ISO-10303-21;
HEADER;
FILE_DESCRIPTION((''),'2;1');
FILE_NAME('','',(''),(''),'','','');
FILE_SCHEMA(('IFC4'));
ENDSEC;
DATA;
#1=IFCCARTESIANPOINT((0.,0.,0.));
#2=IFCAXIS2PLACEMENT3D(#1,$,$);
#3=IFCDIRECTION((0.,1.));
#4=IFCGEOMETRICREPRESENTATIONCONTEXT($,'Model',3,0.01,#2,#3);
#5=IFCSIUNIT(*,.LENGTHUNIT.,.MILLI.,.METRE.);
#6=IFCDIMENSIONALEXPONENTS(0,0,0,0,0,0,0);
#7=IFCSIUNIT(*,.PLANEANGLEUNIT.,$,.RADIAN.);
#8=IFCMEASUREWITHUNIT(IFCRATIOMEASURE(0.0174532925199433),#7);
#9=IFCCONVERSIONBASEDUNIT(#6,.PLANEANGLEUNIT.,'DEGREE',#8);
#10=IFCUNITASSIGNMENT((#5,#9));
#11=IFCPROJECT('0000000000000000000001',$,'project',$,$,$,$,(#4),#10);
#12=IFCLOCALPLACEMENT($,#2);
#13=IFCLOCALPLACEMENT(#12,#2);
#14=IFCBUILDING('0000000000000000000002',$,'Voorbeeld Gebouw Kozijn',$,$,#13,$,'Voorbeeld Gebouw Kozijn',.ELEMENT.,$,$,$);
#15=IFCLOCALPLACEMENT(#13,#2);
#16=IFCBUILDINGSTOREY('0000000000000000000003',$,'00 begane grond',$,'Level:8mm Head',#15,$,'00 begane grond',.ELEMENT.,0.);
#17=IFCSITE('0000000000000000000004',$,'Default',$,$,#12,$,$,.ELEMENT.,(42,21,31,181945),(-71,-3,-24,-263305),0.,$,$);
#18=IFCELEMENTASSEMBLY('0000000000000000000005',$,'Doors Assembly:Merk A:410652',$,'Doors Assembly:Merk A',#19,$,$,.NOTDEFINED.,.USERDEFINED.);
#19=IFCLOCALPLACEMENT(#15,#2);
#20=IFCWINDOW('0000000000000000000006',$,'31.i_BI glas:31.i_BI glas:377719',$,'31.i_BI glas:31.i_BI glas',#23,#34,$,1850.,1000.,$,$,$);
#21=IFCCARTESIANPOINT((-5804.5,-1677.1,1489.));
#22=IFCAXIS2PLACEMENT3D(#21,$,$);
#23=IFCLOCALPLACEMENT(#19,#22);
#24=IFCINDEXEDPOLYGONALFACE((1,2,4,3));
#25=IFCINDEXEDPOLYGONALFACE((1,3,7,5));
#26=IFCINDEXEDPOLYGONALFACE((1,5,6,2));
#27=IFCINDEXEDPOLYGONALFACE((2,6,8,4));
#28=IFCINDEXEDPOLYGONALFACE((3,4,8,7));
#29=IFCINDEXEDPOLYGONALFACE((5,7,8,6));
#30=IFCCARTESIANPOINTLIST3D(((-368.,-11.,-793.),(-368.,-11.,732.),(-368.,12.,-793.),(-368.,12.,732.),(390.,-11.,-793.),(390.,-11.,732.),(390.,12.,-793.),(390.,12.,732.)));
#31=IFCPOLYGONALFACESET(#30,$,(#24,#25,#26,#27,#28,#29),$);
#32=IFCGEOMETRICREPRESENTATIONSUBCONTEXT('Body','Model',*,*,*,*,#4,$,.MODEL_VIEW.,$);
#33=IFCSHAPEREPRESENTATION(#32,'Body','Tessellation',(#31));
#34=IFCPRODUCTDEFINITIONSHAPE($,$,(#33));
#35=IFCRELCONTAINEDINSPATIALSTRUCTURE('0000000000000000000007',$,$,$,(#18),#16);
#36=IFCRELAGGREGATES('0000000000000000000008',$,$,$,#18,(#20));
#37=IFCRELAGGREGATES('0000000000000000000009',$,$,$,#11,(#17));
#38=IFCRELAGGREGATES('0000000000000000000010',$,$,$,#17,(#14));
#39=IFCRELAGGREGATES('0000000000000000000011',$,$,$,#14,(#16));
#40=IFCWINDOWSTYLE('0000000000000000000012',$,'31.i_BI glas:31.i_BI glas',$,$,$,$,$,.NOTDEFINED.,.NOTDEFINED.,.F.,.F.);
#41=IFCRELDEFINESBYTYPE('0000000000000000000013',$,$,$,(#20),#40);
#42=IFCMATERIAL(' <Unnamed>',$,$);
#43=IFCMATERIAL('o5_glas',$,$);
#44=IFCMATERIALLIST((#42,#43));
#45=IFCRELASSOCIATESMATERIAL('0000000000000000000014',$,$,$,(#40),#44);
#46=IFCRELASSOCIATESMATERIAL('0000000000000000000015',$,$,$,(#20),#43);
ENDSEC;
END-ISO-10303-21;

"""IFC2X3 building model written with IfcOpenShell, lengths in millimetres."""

from ifc_helpers import new_model, entity, si_unit, converted_unit, direction, frame, frame_2d, origin, place, context, subcontext, project, spatial, rectangle, extrude, source, transform, mapped, material, material_list, type_object, type_shapes, element, aggregate, save


model = new_model("IFC2X3")

# Units and contexts
model_context = context("Model", 3, precision=0.01, world=origin(), true_north=direction((0.0, 1.0)))
body_context = subcontext(model_context, "Body", "Model", "MODEL_VIEW")
ifc_project = project(units=[si_unit("LENGTHUNIT", "METRE", prefix="MILLI"), converted_unit("PLANEANGLEUNIT", "DEGREE", entity("IfcRatioMeasure", 0.0174532925199433), si_unit("PLANEANGLEUNIT", "RADIAN"), dimensions=[0, 0, 0, 0, 0, 0, 0])], contexts=[model_context])

# Site, building, storey
site_placement = place(None, origin())
site = spatial("IfcSite", under=ifc_project, at=site_placement, Name="Default", CompositionType="ELEMENT", RefLatitude=(42, 21, 31, 181945), RefLongitude=(-71, -3, -24, -263305), RefElevation=0.0)
building_placement = place(site_placement, origin())
building = spatial("IfcBuilding", under=site, at=building_placement, Name="Voorbeeld Gebouw Kozijn", LongName="Voorbeeld Gebouw Kozijn", CompositionType="ELEMENT")
storey_placement = place(building_placement, origin())
storey = spatial("IfcBuildingStorey", under=building, at=storey_placement, Name="00 begane grond", ObjectType="Level:8mm Head", LongName="00 begane grond", CompositionType="ELEMENT", Elevation=0.0)

# Element assembly, window
assembly_placement = place(storey_placement, origin())
assembly = element("IfcElementAssembly", 1, at=assembly_placement, inside=storey, Name="Doors Assembly:Merk A:410652", ObjectType="Doors Assembly:Merk A", AssemblyPlace="NOTDEFINED", PredefinedType="USERDEFINED")
ifc_material_1 = material(Name="o5_glas")
ifc_material_2 = material(Name=" <Unnamed>")
ifc_material_list = material_list([ifc_material_2, ifc_material_1])
window_style = type_object("IfcWindowStyle", Name="31.i_BI glas:31.i_BI glas", ConstructionType="NOTDEFINED", OperationType="NOTDEFINED", ParameterTakesPrecedence=False, Sizeable=False, material=ifc_material_list)
shared_shape = source(origin(), body_context, "Body", "SweptSolid", [
    extrude(rectangle(XDim=23.0, YDim=758.0, at=frame_2d((0.0, 0.0), x_axis=(1.0, 0.0))), frame((11.0, 0.5, -793.0), z_axis=(0.0, 0.0, 1.0), x_axis=(0.0, 1.0, 0.0)), (0.0, 0.0, 1.0), 1525.0),
])
type_shapes(window_style, [shared_shape])
window_placement = place(assembly_placement, frame((-5804.5, -1677.1, 1489.0)))
window = element("IfcWindow", 2, at=window_placement, type_object=window_style, material=ifc_material_1, Name="31.i_BI glas:31.i_BI glas:377719", ObjectType="31.i_BI glas:31.i_BI glas", OverallHeight=1850.0, OverallWidth=1000.0, context=body_context, shape_type="MappedRepresentation", body=[
    mapped(shared_shape, transform((0.0, 0.0, 0.0), scale=1.0)),
])
aggregate(assembly, [window])

save(model, "model.ifc")
